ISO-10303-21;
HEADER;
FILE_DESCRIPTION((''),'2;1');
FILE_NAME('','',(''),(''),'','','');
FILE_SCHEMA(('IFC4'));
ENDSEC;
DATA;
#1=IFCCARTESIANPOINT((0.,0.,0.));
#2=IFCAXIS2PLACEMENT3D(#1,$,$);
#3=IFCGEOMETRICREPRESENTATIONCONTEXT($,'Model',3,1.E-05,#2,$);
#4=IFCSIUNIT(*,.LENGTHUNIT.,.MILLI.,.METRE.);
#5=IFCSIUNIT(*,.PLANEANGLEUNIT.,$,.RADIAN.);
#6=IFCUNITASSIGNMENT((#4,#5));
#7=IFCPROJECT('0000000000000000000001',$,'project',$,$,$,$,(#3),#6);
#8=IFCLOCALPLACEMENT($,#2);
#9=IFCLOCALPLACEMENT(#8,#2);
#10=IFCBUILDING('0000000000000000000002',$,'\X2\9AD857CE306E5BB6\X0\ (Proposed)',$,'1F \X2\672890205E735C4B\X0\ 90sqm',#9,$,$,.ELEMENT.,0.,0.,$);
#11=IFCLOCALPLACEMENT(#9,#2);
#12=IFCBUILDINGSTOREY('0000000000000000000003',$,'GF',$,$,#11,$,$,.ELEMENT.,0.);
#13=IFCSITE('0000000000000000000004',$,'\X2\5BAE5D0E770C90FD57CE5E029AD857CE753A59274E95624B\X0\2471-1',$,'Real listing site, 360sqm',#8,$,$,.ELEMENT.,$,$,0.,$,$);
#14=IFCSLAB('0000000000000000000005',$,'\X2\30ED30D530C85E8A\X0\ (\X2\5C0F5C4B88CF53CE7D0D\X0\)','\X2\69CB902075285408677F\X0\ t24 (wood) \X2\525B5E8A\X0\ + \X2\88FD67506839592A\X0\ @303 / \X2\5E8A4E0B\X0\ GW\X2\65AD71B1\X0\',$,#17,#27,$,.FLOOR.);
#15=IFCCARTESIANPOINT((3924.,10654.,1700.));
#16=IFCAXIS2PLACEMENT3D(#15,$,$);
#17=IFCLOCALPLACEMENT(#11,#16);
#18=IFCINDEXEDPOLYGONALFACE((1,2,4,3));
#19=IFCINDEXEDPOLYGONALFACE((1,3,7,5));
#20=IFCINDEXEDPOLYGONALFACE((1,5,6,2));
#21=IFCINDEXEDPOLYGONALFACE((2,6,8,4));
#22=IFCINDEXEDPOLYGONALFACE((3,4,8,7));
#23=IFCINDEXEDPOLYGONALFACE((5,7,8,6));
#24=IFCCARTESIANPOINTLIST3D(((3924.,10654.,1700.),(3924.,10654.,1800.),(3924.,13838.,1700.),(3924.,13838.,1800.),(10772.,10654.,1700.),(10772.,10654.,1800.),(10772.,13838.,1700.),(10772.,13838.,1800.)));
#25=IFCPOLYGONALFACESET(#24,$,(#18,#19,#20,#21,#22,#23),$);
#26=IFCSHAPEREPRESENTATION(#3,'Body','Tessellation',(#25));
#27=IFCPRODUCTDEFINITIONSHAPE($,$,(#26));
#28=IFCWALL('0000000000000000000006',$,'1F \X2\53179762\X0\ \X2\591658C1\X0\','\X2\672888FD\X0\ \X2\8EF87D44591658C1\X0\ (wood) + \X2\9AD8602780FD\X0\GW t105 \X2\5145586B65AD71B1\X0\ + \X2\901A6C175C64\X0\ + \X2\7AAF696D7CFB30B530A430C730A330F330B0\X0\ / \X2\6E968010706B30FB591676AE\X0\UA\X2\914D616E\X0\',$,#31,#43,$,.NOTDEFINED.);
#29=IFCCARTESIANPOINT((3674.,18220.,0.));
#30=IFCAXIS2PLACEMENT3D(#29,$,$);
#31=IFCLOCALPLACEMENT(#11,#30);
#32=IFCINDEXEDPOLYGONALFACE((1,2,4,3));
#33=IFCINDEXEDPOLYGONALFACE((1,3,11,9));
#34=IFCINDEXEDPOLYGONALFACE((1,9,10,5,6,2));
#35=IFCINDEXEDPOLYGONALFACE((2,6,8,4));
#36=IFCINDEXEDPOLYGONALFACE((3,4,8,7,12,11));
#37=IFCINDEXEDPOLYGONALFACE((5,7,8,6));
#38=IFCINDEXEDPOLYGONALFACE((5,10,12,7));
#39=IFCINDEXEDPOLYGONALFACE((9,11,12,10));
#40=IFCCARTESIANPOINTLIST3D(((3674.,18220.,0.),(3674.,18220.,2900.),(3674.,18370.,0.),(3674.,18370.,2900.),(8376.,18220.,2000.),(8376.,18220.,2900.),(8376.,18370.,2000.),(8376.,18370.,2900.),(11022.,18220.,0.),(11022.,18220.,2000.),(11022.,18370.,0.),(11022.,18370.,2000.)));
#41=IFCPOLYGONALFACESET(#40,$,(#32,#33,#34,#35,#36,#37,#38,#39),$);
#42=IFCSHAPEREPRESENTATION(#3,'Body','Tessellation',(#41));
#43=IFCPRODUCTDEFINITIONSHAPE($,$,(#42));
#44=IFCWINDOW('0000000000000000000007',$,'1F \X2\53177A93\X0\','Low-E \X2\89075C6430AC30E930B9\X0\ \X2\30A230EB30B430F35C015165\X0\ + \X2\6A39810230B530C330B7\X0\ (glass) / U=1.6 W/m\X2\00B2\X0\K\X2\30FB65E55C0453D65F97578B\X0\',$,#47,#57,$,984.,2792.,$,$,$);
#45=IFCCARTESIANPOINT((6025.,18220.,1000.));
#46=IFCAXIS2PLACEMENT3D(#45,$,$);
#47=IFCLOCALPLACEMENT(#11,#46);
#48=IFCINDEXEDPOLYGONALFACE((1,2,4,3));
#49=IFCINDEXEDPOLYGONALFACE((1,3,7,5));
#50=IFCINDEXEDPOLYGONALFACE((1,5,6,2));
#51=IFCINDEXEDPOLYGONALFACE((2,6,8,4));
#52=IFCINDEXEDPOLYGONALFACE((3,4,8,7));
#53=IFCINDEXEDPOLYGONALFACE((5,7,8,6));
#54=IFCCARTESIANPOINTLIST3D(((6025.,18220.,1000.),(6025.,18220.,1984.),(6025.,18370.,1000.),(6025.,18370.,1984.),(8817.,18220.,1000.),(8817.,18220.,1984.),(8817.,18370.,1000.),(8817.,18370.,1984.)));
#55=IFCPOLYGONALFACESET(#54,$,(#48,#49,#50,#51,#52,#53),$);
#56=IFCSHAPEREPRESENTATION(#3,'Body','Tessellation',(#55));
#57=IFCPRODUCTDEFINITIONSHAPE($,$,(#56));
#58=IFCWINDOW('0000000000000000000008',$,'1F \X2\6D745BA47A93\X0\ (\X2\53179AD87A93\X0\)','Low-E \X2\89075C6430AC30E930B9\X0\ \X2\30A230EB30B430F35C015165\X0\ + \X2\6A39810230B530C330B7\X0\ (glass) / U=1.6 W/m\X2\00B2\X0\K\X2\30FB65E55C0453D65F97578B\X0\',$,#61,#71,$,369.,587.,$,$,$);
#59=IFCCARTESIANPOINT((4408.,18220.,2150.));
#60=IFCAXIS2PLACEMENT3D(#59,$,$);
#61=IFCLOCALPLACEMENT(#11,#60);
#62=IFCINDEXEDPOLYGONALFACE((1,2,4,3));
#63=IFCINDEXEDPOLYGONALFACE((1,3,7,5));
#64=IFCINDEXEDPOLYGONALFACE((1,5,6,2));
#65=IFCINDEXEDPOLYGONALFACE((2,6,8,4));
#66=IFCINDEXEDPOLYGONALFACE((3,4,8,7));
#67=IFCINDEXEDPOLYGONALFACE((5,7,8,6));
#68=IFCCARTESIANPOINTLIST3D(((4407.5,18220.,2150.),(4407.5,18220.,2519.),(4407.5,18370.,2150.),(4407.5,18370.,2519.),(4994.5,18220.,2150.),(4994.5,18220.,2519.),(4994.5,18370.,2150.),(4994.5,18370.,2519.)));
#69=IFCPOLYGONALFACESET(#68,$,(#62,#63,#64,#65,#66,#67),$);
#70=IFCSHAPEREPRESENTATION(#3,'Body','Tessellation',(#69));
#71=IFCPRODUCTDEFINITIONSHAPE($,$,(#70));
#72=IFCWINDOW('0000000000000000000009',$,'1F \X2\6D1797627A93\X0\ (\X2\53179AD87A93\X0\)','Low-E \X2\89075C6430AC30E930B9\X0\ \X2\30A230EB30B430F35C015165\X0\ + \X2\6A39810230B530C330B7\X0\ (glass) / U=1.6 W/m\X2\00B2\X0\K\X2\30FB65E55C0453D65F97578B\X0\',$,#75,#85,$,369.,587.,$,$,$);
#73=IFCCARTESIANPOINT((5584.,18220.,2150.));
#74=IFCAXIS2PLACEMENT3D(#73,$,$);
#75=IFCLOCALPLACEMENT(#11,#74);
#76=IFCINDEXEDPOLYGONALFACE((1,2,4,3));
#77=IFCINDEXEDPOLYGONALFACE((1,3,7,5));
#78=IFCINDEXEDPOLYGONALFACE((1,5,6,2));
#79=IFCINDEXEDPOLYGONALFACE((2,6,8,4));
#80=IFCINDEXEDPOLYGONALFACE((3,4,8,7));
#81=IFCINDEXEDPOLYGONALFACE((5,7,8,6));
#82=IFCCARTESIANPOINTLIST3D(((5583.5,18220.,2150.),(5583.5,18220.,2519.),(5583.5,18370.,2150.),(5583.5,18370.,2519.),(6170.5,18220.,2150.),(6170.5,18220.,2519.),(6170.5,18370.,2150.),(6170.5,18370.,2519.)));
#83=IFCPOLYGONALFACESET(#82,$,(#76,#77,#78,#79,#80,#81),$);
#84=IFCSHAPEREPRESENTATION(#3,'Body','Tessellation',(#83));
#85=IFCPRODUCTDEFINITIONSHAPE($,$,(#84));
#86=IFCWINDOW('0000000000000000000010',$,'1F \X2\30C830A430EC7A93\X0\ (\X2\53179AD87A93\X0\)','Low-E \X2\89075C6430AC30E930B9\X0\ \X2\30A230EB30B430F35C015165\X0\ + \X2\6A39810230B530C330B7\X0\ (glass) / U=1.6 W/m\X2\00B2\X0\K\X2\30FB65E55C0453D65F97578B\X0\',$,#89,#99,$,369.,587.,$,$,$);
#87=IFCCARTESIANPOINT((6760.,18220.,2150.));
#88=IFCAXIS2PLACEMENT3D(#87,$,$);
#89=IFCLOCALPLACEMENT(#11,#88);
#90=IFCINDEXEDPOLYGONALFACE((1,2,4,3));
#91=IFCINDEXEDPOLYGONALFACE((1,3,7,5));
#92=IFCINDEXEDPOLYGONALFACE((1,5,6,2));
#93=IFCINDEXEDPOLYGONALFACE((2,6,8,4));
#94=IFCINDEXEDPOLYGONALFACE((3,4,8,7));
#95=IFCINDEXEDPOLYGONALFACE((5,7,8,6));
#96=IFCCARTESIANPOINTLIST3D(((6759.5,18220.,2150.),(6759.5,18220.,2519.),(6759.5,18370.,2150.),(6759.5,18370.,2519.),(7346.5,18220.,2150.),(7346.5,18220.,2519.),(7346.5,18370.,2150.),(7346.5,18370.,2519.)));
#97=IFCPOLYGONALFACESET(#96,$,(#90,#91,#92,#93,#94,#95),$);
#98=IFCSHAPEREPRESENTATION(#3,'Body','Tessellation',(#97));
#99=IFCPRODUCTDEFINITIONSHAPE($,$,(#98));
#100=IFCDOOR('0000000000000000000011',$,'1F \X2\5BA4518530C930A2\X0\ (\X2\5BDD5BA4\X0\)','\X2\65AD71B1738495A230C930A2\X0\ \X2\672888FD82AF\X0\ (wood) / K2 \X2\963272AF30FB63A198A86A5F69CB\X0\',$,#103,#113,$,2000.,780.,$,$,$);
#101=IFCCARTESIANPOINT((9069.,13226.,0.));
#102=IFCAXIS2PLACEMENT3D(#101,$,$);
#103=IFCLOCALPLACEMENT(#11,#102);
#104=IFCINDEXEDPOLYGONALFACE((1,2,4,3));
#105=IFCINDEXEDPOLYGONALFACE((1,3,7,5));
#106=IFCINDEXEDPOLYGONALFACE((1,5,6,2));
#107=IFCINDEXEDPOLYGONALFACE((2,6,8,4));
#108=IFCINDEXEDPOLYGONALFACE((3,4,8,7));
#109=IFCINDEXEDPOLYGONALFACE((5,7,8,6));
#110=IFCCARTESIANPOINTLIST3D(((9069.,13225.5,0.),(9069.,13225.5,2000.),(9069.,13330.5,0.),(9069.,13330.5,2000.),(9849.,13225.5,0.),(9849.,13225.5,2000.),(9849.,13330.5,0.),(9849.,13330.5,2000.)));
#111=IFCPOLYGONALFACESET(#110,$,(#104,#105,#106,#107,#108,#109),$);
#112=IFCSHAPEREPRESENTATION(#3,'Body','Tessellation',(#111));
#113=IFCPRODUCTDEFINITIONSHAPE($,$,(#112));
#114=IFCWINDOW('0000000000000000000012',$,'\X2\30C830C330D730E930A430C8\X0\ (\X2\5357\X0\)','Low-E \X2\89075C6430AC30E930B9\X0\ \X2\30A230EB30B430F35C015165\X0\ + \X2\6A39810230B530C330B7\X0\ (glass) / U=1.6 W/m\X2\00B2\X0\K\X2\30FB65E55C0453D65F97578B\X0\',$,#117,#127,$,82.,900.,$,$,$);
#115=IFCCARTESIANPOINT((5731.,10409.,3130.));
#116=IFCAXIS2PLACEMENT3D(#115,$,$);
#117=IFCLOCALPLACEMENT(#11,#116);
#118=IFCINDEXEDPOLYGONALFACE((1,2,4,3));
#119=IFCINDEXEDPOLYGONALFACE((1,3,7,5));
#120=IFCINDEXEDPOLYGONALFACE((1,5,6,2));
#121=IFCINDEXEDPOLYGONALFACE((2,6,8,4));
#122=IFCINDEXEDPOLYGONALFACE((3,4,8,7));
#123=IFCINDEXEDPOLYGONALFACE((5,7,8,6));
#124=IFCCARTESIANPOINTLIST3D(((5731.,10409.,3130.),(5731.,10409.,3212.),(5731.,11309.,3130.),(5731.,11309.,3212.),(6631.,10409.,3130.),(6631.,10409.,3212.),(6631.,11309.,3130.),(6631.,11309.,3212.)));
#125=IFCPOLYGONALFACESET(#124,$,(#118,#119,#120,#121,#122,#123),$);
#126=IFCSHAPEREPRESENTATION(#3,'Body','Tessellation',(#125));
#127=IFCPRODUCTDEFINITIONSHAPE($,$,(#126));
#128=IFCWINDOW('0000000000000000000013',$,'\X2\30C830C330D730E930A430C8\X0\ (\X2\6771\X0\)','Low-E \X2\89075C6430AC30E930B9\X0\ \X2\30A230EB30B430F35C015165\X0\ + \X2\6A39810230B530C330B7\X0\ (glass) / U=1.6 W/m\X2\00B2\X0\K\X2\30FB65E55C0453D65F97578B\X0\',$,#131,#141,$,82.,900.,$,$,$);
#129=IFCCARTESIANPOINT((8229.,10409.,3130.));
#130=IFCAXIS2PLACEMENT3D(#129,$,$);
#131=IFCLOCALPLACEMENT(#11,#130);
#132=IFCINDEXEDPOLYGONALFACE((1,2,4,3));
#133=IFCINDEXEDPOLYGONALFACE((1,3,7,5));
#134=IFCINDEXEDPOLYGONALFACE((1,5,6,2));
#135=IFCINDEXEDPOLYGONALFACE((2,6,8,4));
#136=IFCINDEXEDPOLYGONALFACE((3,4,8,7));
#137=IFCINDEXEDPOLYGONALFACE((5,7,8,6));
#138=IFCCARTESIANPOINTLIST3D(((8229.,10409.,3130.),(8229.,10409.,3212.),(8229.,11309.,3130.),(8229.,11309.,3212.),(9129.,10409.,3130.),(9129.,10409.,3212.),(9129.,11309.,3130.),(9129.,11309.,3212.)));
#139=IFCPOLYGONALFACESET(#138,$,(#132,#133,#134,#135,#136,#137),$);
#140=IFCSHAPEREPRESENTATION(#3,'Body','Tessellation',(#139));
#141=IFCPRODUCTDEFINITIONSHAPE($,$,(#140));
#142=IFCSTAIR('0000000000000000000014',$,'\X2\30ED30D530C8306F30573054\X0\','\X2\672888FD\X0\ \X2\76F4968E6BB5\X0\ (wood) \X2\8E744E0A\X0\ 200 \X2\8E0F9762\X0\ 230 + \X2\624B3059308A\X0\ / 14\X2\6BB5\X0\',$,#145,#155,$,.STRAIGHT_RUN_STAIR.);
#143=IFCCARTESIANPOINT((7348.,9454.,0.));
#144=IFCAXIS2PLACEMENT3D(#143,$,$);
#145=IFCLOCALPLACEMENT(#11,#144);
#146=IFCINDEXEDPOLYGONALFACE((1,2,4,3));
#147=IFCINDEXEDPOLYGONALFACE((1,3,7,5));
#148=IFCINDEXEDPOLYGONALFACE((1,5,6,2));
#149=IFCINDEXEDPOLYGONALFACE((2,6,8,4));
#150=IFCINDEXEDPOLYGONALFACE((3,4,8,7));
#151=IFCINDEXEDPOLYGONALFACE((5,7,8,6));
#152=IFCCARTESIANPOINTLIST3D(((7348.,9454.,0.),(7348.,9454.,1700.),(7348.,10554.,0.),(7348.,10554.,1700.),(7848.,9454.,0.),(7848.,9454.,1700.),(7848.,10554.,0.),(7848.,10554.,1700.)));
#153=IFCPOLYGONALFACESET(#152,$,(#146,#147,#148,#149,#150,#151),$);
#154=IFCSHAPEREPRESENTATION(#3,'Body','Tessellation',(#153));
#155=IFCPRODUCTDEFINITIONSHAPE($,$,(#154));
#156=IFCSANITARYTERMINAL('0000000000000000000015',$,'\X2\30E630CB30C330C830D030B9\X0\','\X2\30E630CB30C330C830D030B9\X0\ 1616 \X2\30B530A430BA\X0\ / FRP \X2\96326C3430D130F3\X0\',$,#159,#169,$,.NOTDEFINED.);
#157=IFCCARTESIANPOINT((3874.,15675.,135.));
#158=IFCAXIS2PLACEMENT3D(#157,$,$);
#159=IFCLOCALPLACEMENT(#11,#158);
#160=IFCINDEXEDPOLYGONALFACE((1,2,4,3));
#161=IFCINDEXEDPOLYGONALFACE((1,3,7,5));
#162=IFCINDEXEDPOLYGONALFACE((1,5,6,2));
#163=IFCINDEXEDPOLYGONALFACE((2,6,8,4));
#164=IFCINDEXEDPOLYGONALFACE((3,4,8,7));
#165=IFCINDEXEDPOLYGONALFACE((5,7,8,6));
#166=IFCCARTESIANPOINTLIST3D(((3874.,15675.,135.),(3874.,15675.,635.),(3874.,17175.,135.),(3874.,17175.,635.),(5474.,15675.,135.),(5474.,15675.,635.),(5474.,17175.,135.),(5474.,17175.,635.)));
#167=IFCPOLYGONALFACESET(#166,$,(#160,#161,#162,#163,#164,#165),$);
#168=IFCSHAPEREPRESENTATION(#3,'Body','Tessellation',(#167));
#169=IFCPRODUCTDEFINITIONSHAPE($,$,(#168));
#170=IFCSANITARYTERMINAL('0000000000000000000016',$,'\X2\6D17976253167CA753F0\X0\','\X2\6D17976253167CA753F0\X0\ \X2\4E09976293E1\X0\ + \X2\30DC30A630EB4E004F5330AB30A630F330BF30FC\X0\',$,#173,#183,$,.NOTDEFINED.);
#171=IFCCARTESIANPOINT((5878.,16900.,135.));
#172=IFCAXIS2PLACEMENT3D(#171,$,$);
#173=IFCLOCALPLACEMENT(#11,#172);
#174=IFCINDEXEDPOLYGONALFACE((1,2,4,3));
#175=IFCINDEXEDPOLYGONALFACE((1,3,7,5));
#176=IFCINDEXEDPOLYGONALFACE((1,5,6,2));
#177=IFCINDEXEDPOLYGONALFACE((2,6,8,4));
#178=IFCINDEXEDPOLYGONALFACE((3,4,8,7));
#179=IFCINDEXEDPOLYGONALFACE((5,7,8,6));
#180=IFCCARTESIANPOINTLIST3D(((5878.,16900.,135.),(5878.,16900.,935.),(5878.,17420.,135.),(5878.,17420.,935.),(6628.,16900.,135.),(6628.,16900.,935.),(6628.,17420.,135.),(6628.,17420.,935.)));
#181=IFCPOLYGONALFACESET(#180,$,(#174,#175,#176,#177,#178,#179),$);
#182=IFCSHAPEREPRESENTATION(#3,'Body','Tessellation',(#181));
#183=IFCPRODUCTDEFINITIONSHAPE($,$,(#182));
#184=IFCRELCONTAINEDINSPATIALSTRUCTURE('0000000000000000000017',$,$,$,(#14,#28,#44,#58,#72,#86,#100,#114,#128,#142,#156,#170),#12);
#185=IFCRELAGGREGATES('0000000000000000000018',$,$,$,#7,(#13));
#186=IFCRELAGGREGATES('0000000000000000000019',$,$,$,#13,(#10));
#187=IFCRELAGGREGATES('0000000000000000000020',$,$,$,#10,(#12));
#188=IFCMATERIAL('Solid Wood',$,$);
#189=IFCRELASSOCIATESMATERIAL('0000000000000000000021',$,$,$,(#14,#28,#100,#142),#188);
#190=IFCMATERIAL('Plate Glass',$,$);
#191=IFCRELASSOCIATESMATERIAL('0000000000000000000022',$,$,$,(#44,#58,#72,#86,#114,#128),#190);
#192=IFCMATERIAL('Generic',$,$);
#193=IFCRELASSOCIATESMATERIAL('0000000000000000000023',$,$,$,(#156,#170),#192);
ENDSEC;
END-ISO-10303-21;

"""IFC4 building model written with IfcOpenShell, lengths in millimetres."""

from ifc_helpers import new_model, si_unit, frame, frame_2d, origin, place, context, project, spatial, rectangle, extrude, material, element, fill, save


model = new_model("IFC4")

# Units and contexts
model_context = context("Model", 3, precision=1e-05, world=origin())
ifc_project = project(units=[si_unit("LENGTHUNIT", "METRE", prefix="MILLI"), si_unit("PLANEANGLEUNIT", "RADIAN")], contexts=[model_context])

# Site, building, storey
site_placement = place(None, origin())
site = spatial("IfcSite", under=ifc_project, at=site_placement, Name="宮崎県都城市高城町大井手2471-1", ObjectType="Real listing site, 360sqm", CompositionType="ELEMENT", RefElevation=0.0)
building_placement = place(site_placement, origin())
building = spatial("IfcBuilding", under=site, at=building_placement, Name="高城の家 (Proposed)", ObjectType="1F 木造平屋 90sqm", CompositionType="ELEMENT", ElevationOfRefHeight=0.0, ElevationOfTerrain=0.0)
storey_placement = place(building_placement, origin())
storey = spatial("IfcBuildingStorey", under=building, at=storey_placement, Name="GF", CompositionType="ELEMENT", Elevation=0.0)

# Slab
ifc_material_1 = material(Name="Solid Wood")
slab_placement = place(storey_placement, frame((3924.0, 10654.0, 1700.0)))
element("IfcSlab", 1, at=slab_placement, inside=storey, material=ifc_material_1, Name="ロフト床 (小屋裏収納)", Description="構造用合板 t24 (wood) 剛床 + 製材根太 @303 / 床下 GW断熱", PredefinedType="FLOOR", context=model_context, shape_type="SweptSolid", body=[
    extrude(rectangle(XDim=6848.0, YDim=3184.0, at=frame_2d((3424.0, 1592.0))), frame((3924.0, 10654.0, 1700.0)), (0.0, 0.0, 1.0), 100.0),
])

# Wall, openings, windows
wall_1_placement = place(storey_placement, frame((3674.0, 18220.0, 0.0)))
wall_1 = element("IfcWall", 2, at=wall_1_placement, inside=storey, material=ifc_material_1, Name="1F 北面 外壁", Description="木製 軸組外壁 (wood) + 高性能GW t105 充填断熱 + 通気層 + 窯業系サイディング / 準耐火・外皮UA配慮", PredefinedType="NOTDEFINED", context=model_context, shape_type="SweptSolid", body=[
    extrude(rectangle(XDim=7348.0, YDim=150.0, at=frame_2d((3674.0, 75.0))), frame((3674.0, 18220.0, 0.0)), (0.0, 0.0, 1.0), 2900.0),
])
opening_1_placement = place(storey_placement, frame((6025.0, 18220.0, 1000.0)))
opening_1 = element("IfcOpeningElement", 3, at=opening_1_placement, cuts=wall_1, PredefinedType="NOTDEFINED", context=model_context, shape_type="SweptSolid", body=[
    extrude(rectangle(XDim=2792.0, YDim=150.0, at=frame_2d((1396.0, 75.0))), frame((6025.0, 18220.0, 1000.0)), (0.0, 0.0, 1.0), 984.0),
])
opening_2_placement = place(storey_placement, frame((4408.0, 18220.0, 2150.0)))
opening_2 = element("IfcOpeningElement", 4, at=opening_2_placement, cuts=wall_1, PredefinedType="NOTDEFINED", context=model_context, shape_type="SweptSolid", body=[
    extrude(rectangle(XDim=587.0, YDim=150.0, at=frame_2d((293.0, 75.0))), frame((4408.0, 18220.0, 2150.0)), (0.0, 0.0, 1.0), 369.0),
])
opening_3_placement = place(storey_placement, frame((5584.0, 18220.0, 2150.0)))
opening_3 = element("IfcOpeningElement", 5, at=opening_3_placement, cuts=wall_1, PredefinedType="NOTDEFINED", context=model_context, shape_type="SweptSolid", body=[
    extrude(rectangle(XDim=587.0, YDim=150.0, at=frame_2d((293.0, 75.0))), frame((5584.0, 18220.0, 2150.0)), (0.0, 0.0, 1.0), 369.0),
])
opening_4_placement = place(storey_placement, frame((6760.0, 18220.0, 2150.0)))
opening_4 = element("IfcOpeningElement", 6, at=opening_4_placement, cuts=wall_1, PredefinedType="NOTDEFINED", context=model_context, shape_type="SweptSolid", body=[
    extrude(rectangle(XDim=587.0, YDim=150.0, at=frame_2d((293.0, 75.0))), frame((6760.0, 18220.0, 2150.0)), (0.0, 0.0, 1.0), 369.0),
])
ifc_material_2 = material(Name="Plate Glass")
window_1_placement = place(storey_placement, frame((6025.0, 18220.0, 1000.0)))
window_1 = element("IfcWindow", 7, at=window_1_placement, inside=storey, material=ifc_material_2, Name="1F 北窓", Description="Low-E 複層ガラス アルゴン封入 + 樹脂サッシ (glass) / U=1.6 W/m²K・日射取得型", OverallHeight=984.0, OverallWidth=2792.0, context=model_context, shape_type="SweptSolid", body=[
    extrude(rectangle(XDim=2792.0, YDim=150.0, at=frame_2d((1396.0, 75.0))), frame((6025.0, 18220.0, 1000.0)), (0.0, 0.0, 1.0), 984.0),
])
fill(opening_1, window_1)
window_2_placement = place(storey_placement, frame((4408.0, 18220.0, 2150.0)))
window_2 = element("IfcWindow", 8, at=window_2_placement, inside=storey, material=ifc_material_2, Name="1F 浴室窓 (北高窓)", Description="Low-E 複層ガラス アルゴン封入 + 樹脂サッシ (glass) / U=1.6 W/m²K・日射取得型", OverallHeight=369.0, OverallWidth=587.0, context=model_context, shape_type="SweptSolid", body=[
    extrude(rectangle(XDim=587.0, YDim=150.0, at=frame_2d((293.0, 75.0))), frame((4408.0, 18220.0, 2150.0)), (0.0, 0.0, 1.0), 369.0),
])
fill(opening_2, window_2)
window_3_placement = place(storey_placement, frame((5584.0, 18220.0, 2150.0)))
window_3 = element("IfcWindow", 9, at=window_3_placement, inside=storey, material=ifc_material_2, Name="1F 洗面窓 (北高窓)", Description="Low-E 複層ガラス アルゴン封入 + 樹脂サッシ (glass) / U=1.6 W/m²K・日射取得型", OverallHeight=369.0, OverallWidth=587.0, context=model_context, shape_type="SweptSolid", body=[
    extrude(rectangle(XDim=587.0, YDim=150.0, at=frame_2d((293.0, 75.0))), frame((5584.0, 18220.0, 2150.0)), (0.0, 0.0, 1.0), 369.0),
])
fill(opening_3, window_3)
window_4_placement = place(storey_placement, frame((6760.0, 18220.0, 2150.0)))
window_4 = element("IfcWindow", 10, at=window_4_placement, inside=storey, material=ifc_material_2, Name="1F トイレ窓 (北高窓)", Description="Low-E 複層ガラス アルゴン封入 + 樹脂サッシ (glass) / U=1.6 W/m²K・日射取得型", OverallHeight=369.0, OverallWidth=587.0, context=model_context, shape_type="SweptSolid", body=[
    extrude(rectangle(XDim=587.0, YDim=150.0, at=frame_2d((293.0, 75.0))), frame((6760.0, 18220.0, 2150.0)), (0.0, 0.0, 1.0), 369.0),
])
fill(opening_4, window_4)

# Door
door_1_placement = place(storey_placement, frame((9069.0, 13226.0, 0.0)))
element("IfcDoor", 11, at=door_1_placement, inside=storey, material=ifc_material_1, Name="1F 室内ドア (寝室)", Description="断熱玄関ドア 木製芯 (wood) / K2 防犯・採風機構", OverallHeight=2000.0, OverallWidth=780.0, context=model_context, shape_type="SweptSolid", body=[
    extrude(rectangle(XDim=780.0, YDim=105.0, at=frame_2d((390.0, 52.0))), frame((9069.0, 13226.0, 0.0)), (0.0, 0.0, 1.0), 2000.0),
])

# Windows
window_5_placement = place(storey_placement, frame((5731.0, 10409.0, 3130.0)))
element("IfcWindow", 12, at=window_5_placement, inside=storey, material=ifc_material_2, Name="トップライト (南)", Description="Low-E 複層ガラス アルゴン封入 + 樹脂サッシ (glass) / U=1.6 W/m²K・日射取得型", OverallHeight=82.0, OverallWidth=900.0, context=model_context, shape_type="SweptSolid", body=[
    extrude(rectangle(XDim=900.0, YDim=900.0, at=frame_2d((450.0, 450.0))), frame((5731.0, 10409.0, 3130.0)), (0.0, 0.0, 1.0), 82.0),
])
window_6_placement = place(storey_placement, frame((8229.0, 10409.0, 3130.0)))
element("IfcWindow", 13, at=window_6_placement, inside=storey, material=ifc_material_2, Name="トップライト (東)", Description="Low-E 複層ガラス アルゴン封入 + 樹脂サッシ (glass) / U=1.6 W/m²K・日射取得型", OverallHeight=82.0, OverallWidth=900.0, context=model_context, shape_type="SweptSolid", body=[
    extrude(rectangle(XDim=900.0, YDim=900.0, at=frame_2d((450.0, 450.0))), frame((8229.0, 10409.0, 3130.0)), (0.0, 0.0, 1.0), 82.0),
])

# Stair
stair_placement = place(storey_placement, frame((7348.0, 9454.0, 0.0)))
element("IfcStair", 14, at=stair_placement, inside=storey, material=ifc_material_1, Name="ロフトはしご", Description="木製 直階段 (wood) 蹴上 200 踏面 230 + 手すり / 14段", PredefinedType="STRAIGHT_RUN_STAIR", context=model_context, shape_type="SweptSolid", body=[
    extrude(rectangle(XDim=500.0, YDim=1100.0, at=frame_2d((250.0, 550.0))), frame((7348.0, 9454.0, 0.0)), (0.0, 0.0, 1.0), 1700.0),
])

# Sanitary terminals
ifc_material_3 = material(Name="Generic")
sanitary_terminal_1_placement = place(storey_placement, frame((3874.0, 15675.0, 135.0)))
element("IfcSanitaryTerminal", 15, at=sanitary_terminal_1_placement, inside=storey, material=ifc_material_3, Name="ユニットバス", Description="ユニットバス 1616 サイズ / FRP 防水パン", PredefinedType="NOTDEFINED", context=model_context, shape_type="SweptSolid", body=[
    extrude(rectangle(XDim=1600.0, YDim=1500.0, at=frame_2d((800.0, 750.0))), frame((3874.0, 15675.0, 135.0)), (0.0, 0.0, 1.0), 500.0),
])
sanitary_terminal_2_placement = place(storey_placement, frame((5878.0, 16900.0, 135.0)))
element("IfcSanitaryTerminal", 16, at=sanitary_terminal_2_placement, inside=storey, material=ifc_material_3, Name="洗面化粧台", Description="洗面化粧台 三面鏡 + ボウル一体カウンター", PredefinedType="NOTDEFINED", context=model_context, shape_type="SweptSolid", body=[
    extrude(rectangle(XDim=750.0, YDim=520.0, at=frame_2d((375.0, 260.0))), frame((5878.0, 16900.0, 135.0)), (0.0, 0.0, 1.0), 800.0),
])

save(model, "model.ifc")
